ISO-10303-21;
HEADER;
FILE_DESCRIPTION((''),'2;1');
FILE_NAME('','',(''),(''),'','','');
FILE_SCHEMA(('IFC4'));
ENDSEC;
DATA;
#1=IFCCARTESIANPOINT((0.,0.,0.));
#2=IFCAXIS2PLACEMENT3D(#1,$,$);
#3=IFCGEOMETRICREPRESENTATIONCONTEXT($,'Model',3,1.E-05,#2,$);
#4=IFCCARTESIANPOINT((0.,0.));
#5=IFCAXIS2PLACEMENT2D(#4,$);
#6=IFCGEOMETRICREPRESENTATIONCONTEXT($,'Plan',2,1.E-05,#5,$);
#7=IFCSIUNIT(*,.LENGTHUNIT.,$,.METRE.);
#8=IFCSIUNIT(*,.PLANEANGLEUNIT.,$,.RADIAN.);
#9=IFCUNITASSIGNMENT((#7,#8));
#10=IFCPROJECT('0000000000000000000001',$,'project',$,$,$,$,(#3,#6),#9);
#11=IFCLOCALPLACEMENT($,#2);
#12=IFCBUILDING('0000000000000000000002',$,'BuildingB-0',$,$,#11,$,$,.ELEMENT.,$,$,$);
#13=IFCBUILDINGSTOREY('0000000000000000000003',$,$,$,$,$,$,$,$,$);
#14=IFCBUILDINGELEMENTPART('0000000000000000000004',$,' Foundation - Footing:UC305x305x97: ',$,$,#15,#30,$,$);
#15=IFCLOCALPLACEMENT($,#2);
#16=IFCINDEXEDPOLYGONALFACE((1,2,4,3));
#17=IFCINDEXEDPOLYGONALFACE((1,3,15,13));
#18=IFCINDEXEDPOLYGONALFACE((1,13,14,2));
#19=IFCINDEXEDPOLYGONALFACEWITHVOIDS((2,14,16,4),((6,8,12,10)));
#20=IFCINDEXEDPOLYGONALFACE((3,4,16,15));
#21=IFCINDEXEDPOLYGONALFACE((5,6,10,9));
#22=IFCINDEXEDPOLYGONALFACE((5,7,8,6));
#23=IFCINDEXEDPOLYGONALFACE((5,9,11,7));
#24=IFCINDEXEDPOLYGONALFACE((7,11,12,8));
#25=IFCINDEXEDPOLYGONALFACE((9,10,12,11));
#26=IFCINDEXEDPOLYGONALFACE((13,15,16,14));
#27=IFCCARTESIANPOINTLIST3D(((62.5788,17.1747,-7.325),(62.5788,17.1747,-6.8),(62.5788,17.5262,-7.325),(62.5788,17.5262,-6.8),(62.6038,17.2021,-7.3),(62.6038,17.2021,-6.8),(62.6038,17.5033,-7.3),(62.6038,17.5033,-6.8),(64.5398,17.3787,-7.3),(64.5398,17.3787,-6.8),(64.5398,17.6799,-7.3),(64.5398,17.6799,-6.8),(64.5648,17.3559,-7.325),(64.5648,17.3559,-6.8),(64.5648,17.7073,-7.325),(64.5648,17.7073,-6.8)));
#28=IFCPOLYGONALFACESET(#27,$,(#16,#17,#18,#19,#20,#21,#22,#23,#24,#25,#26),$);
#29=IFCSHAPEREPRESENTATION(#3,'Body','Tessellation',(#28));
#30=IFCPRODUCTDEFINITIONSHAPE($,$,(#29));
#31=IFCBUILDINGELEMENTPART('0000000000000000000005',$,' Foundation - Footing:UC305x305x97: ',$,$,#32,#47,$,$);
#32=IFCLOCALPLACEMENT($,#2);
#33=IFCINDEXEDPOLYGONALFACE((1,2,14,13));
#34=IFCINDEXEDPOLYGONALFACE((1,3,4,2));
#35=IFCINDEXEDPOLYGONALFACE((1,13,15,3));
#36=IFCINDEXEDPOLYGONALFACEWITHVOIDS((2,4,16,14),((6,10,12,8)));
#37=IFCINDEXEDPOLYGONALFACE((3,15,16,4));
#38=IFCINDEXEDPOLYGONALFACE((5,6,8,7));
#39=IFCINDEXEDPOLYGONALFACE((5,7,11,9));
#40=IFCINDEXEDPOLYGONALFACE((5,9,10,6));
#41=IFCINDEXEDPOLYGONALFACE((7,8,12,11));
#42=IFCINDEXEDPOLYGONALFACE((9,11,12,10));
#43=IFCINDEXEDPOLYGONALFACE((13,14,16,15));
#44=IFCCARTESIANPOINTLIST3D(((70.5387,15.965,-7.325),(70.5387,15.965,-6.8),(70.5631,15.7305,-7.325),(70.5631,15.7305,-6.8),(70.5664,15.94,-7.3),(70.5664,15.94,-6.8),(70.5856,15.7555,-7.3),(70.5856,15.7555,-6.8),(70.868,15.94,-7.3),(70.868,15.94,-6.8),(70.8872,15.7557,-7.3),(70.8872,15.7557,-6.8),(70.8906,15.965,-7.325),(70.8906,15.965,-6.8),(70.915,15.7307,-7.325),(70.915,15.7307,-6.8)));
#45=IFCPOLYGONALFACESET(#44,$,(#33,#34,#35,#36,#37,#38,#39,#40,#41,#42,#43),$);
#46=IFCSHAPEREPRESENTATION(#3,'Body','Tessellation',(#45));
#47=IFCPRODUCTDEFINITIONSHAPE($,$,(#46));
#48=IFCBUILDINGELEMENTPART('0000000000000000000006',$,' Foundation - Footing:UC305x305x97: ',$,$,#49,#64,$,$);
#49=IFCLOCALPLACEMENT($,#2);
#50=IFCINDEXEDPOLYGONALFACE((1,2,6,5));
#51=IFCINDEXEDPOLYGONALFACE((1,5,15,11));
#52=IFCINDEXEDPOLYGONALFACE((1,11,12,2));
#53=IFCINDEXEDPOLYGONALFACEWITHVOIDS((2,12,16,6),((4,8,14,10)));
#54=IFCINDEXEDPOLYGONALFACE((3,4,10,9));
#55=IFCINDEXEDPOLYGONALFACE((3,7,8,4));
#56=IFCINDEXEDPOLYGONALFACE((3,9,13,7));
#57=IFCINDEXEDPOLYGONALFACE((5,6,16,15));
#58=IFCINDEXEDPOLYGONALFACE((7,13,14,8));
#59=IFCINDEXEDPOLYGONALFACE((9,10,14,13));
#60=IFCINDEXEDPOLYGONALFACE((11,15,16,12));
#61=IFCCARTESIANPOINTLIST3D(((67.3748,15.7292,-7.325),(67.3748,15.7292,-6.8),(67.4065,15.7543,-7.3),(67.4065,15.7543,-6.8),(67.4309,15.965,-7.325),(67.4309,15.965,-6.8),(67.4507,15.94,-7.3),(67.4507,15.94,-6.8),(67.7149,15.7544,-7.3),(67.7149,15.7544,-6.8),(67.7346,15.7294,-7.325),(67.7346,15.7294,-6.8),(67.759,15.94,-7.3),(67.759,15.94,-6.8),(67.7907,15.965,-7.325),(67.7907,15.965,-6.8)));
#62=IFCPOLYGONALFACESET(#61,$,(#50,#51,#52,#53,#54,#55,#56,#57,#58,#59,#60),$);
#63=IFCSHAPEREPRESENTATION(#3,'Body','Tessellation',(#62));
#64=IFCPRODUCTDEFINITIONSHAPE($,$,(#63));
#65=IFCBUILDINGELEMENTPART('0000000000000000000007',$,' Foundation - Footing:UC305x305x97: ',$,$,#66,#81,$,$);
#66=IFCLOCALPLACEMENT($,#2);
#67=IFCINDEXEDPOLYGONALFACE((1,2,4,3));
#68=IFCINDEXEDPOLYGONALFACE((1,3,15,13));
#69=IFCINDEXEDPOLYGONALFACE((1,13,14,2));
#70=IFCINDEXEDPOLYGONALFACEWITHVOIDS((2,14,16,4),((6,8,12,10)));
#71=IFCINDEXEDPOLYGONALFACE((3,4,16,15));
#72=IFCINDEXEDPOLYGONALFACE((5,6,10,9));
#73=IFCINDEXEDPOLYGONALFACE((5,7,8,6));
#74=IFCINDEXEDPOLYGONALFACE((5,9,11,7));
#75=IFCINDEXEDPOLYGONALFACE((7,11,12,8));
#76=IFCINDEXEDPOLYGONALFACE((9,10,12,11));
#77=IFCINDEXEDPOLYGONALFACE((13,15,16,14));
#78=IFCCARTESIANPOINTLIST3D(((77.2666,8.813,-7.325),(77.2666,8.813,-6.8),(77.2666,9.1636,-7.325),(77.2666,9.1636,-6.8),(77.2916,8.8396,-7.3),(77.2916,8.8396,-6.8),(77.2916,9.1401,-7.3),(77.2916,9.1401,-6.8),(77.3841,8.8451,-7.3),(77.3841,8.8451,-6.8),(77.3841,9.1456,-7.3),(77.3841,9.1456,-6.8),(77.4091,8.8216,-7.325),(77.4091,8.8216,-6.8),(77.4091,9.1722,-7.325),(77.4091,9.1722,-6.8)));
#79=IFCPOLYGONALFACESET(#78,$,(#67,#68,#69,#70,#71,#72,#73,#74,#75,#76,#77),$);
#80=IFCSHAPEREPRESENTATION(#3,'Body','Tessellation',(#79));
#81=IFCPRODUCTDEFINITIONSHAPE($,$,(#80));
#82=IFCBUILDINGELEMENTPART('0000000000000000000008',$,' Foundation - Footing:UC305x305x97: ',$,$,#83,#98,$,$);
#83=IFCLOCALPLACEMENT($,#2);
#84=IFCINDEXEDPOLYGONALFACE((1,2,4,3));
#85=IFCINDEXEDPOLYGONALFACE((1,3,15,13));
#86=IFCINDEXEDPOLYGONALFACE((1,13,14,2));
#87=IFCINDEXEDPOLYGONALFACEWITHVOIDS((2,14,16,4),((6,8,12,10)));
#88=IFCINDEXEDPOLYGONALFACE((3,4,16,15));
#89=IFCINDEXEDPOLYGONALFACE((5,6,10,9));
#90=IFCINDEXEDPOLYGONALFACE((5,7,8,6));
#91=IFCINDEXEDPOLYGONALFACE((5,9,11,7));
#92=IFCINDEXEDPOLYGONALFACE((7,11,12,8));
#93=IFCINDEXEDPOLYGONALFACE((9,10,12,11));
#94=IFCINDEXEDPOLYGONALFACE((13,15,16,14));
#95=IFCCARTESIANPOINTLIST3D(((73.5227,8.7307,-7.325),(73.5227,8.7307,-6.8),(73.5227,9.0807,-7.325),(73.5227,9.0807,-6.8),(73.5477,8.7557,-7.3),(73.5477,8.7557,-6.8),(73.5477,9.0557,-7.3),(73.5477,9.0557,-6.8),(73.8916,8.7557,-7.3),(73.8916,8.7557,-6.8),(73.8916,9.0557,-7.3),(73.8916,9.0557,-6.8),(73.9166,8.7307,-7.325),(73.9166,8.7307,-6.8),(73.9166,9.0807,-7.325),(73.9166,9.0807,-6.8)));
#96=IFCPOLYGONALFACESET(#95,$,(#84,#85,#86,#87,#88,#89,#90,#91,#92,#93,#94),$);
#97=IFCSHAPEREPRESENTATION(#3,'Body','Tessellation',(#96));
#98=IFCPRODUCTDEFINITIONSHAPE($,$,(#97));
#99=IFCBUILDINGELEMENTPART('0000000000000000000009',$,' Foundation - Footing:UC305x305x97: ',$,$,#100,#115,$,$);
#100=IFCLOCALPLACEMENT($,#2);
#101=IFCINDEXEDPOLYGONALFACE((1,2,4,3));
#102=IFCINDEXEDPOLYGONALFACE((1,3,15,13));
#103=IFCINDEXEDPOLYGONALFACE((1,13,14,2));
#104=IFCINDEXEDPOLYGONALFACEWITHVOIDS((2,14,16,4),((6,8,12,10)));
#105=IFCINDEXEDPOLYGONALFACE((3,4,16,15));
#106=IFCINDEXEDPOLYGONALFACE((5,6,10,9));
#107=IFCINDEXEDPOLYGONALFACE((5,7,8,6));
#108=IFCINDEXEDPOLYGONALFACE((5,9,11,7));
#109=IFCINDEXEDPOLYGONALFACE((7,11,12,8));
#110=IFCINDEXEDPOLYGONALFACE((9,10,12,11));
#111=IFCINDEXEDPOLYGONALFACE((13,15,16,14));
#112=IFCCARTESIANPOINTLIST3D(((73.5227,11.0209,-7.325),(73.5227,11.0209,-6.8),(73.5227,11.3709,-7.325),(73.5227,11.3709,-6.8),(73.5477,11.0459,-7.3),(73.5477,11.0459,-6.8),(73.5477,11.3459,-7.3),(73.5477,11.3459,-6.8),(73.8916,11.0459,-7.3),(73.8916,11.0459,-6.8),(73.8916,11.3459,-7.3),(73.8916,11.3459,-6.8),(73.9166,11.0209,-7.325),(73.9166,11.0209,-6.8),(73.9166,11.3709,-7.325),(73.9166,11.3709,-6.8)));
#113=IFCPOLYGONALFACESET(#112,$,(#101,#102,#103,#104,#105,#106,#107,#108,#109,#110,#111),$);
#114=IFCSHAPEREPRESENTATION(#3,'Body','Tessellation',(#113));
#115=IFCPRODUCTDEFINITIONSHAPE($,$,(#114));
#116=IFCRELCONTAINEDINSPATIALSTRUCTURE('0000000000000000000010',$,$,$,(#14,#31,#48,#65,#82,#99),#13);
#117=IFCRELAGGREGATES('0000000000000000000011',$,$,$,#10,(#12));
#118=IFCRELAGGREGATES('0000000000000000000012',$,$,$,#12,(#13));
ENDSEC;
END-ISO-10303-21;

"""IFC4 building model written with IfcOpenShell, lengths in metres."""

from ifc_helpers import new_model, si_unit, origin, origin_2d, place, context, project, spatial, polyline, outline, extrude, element, save


model = new_model("IFC4")

# Units and contexts
model_context = context("Model", 3, precision=1e-05, world=origin())
plan_context = context("Plan", 2, precision=1e-05, world=origin_2d())
ifc_project = project(units=[si_unit("LENGTHUNIT", "METRE"), si_unit("PLANEANGLEUNIT", "RADIAN")], contexts=[model_context, plan_context])

# Building, storey
building_placement = place(None, origin())
building = spatial("IfcBuilding", under=ifc_project, at=building_placement, Name="BuildingB-0", CompositionType="ELEMENT")
storey = spatial("IfcBuildingStorey", under=building)

# Building element parts, openings
building_element_part_1 = element("IfcBuildingElementPart", 1, inside=storey, Name=" Foundation - Footing:UC305x305x97: ", context=model_context, shape_type="SweptSolid", body=[
    extrude(outline(polyline([(64.5648, 17.3559, -7.325), (64.5648, 17.7073, -7.325), (62.5788, 17.5262, -7.325), (62.5788, 17.1747, -7.325), (64.5648, 17.3559, -7.325)])), None, (0.0, 0.0, 1.0), 0.525),
])
element("IfcOpeningElement", 2, inside=storey, cuts=building_element_part_1, context=model_context, shape_type="SweptSolid", body=[
    extrude(outline(polyline([(64.5398, 17.3787, -7.3), (64.5398, 17.6799, -7.3), (62.6038, 17.5033, -7.3), (62.6038, 17.2021, -7.3), (64.5398, 17.3787, -7.3)])), None, (0.0, 0.0, 1.0), 0.5),
])
building_element_part_2 = element("IfcBuildingElementPart", 3, inside=storey, Name=" Foundation - Footing:UC305x305x97: ", context=model_context, shape_type="SweptSolid", body=[
    extrude(outline(polyline([(70.915, 15.7307, -7.325), (70.8906, 15.965, -7.325), (70.5387, 15.965, -7.325), (70.5631, 15.7305, -7.325), (70.915, 15.7307, -7.325)])), None, (0.0, 0.0, 1.0), 0.525),
])
element("IfcOpeningElement", 4, inside=storey, cuts=building_element_part_2, context=model_context, shape_type="SweptSolid", body=[
    extrude(outline(polyline([(70.8872, 15.7557, -7.3), (70.868, 15.94, -7.3), (70.5664, 15.94, -7.3), (70.5856, 15.7555, -7.3), (70.8872, 15.7557, -7.3)])), None, (0.0, 0.0, 1.0), 0.5),
])
building_element_part_3 = element("IfcBuildingElementPart", 5, inside=storey, Name=" Foundation - Footing:UC305x305x97: ", context=model_context, shape_type="SweptSolid", body=[
    extrude(outline(polyline([(67.7346, 15.7294, -7.325), (67.7907, 15.965, -7.325), (67.4309, 15.965, -7.325), (67.3748, 15.7292, -7.325), (67.7346, 15.7294, -7.325)])), None, (0.0, 0.0, 1.0), 0.525),
])
element("IfcOpeningElement", 6, inside=storey, cuts=building_element_part_3, context=model_context, shape_type="SweptSolid", body=[
    extrude(outline(polyline([(67.7149, 15.7544, -7.3), (67.759, 15.94, -7.3), (67.4507, 15.94, -7.3), (67.4065, 15.7543, -7.3), (67.7149, 15.7544, -7.3)])), None, (0.0, 0.0, 1.0), 0.5),
])
building_element_part_4 = element("IfcBuildingElementPart", 7, inside=storey, Name=" Foundation - Footing:UC305x305x97: ", context=model_context, shape_type="SweptSolid", body=[
    extrude(outline(polyline([(77.4091, 8.8216, -7.325), (77.2666, 8.813, -7.325), (77.2666, 9.1636, -7.325), (77.4091, 9.1722, -7.325), (77.4091, 8.8216, -7.325)])), None, (0.0, 0.0, 1.0), 0.525),
])
element("IfcOpeningElement", 8, inside=storey, cuts=building_element_part_4, context=model_context, shape_type="SweptSolid", body=[
    extrude(outline(polyline([(77.3841, 8.8451, -7.3), (77.2916, 8.8396, -7.3), (77.2916, 9.1401, -7.3), (77.3841, 9.1456, -7.3), (77.3841, 8.8451, -7.3)])), None, (0.0, 0.0, 1.0), 0.5),
])
building_element_part_5 = element("IfcBuildingElementPart", 9, inside=storey, Name=" Foundation - Footing:UC305x305x97: ", context=model_context, shape_type="SweptSolid", body=[
    extrude(outline(polyline([(73.9166, 8.7307, -7.325), (73.5227, 8.7307, -7.325), (73.5227, 9.0807, -7.325), (73.9166, 9.0807, -7.325), (73.9166, 8.7307, -7.325)])), None, (0.0, 0.0, 1.0), 0.525),
])
element("IfcOpeningElement", 10, inside=storey, cuts=building_element_part_5, context=model_context, shape_type="SweptSolid", body=[
    extrude(outline(polyline([(73.8916, 8.7557, -7.3), (73.5477, 8.7557, -7.3), (73.5477, 9.0557, -7.3), (73.8916, 9.0557, -7.3), (73.8916, 8.7557, -7.3)])), None, (0.0, 0.0, 1.0), 0.5),
])
building_element_part_6 = element("IfcBuildingElementPart", 11, inside=storey, Name=" Foundation - Footing:UC305x305x97: ", context=model_context, shape_type="SweptSolid", body=[
    extrude(outline(polyline([(73.9166, 11.0209, -7.325), (73.5227, 11.0209, -7.325), (73.5227, 11.3709, -7.325), (73.9166, 11.3709, -7.325), (73.9166, 11.0209, -7.325)])), None, (0.0, 0.0, 1.0), 0.525),
])
element("IfcOpeningElement", 12, inside=storey, cuts=building_element_part_6, context=model_context, shape_type="SweptSolid", body=[
    extrude(outline(polyline([(73.8916, 11.0459, -7.3), (73.5477, 11.0459, -7.3), (73.5477, 11.3459, -7.3), (73.8916, 11.3459, -7.3), (73.8916, 11.0459, -7.3)])), None, (0.0, 0.0, 1.0), 0.5),
])

save(model, "model.ifc")
